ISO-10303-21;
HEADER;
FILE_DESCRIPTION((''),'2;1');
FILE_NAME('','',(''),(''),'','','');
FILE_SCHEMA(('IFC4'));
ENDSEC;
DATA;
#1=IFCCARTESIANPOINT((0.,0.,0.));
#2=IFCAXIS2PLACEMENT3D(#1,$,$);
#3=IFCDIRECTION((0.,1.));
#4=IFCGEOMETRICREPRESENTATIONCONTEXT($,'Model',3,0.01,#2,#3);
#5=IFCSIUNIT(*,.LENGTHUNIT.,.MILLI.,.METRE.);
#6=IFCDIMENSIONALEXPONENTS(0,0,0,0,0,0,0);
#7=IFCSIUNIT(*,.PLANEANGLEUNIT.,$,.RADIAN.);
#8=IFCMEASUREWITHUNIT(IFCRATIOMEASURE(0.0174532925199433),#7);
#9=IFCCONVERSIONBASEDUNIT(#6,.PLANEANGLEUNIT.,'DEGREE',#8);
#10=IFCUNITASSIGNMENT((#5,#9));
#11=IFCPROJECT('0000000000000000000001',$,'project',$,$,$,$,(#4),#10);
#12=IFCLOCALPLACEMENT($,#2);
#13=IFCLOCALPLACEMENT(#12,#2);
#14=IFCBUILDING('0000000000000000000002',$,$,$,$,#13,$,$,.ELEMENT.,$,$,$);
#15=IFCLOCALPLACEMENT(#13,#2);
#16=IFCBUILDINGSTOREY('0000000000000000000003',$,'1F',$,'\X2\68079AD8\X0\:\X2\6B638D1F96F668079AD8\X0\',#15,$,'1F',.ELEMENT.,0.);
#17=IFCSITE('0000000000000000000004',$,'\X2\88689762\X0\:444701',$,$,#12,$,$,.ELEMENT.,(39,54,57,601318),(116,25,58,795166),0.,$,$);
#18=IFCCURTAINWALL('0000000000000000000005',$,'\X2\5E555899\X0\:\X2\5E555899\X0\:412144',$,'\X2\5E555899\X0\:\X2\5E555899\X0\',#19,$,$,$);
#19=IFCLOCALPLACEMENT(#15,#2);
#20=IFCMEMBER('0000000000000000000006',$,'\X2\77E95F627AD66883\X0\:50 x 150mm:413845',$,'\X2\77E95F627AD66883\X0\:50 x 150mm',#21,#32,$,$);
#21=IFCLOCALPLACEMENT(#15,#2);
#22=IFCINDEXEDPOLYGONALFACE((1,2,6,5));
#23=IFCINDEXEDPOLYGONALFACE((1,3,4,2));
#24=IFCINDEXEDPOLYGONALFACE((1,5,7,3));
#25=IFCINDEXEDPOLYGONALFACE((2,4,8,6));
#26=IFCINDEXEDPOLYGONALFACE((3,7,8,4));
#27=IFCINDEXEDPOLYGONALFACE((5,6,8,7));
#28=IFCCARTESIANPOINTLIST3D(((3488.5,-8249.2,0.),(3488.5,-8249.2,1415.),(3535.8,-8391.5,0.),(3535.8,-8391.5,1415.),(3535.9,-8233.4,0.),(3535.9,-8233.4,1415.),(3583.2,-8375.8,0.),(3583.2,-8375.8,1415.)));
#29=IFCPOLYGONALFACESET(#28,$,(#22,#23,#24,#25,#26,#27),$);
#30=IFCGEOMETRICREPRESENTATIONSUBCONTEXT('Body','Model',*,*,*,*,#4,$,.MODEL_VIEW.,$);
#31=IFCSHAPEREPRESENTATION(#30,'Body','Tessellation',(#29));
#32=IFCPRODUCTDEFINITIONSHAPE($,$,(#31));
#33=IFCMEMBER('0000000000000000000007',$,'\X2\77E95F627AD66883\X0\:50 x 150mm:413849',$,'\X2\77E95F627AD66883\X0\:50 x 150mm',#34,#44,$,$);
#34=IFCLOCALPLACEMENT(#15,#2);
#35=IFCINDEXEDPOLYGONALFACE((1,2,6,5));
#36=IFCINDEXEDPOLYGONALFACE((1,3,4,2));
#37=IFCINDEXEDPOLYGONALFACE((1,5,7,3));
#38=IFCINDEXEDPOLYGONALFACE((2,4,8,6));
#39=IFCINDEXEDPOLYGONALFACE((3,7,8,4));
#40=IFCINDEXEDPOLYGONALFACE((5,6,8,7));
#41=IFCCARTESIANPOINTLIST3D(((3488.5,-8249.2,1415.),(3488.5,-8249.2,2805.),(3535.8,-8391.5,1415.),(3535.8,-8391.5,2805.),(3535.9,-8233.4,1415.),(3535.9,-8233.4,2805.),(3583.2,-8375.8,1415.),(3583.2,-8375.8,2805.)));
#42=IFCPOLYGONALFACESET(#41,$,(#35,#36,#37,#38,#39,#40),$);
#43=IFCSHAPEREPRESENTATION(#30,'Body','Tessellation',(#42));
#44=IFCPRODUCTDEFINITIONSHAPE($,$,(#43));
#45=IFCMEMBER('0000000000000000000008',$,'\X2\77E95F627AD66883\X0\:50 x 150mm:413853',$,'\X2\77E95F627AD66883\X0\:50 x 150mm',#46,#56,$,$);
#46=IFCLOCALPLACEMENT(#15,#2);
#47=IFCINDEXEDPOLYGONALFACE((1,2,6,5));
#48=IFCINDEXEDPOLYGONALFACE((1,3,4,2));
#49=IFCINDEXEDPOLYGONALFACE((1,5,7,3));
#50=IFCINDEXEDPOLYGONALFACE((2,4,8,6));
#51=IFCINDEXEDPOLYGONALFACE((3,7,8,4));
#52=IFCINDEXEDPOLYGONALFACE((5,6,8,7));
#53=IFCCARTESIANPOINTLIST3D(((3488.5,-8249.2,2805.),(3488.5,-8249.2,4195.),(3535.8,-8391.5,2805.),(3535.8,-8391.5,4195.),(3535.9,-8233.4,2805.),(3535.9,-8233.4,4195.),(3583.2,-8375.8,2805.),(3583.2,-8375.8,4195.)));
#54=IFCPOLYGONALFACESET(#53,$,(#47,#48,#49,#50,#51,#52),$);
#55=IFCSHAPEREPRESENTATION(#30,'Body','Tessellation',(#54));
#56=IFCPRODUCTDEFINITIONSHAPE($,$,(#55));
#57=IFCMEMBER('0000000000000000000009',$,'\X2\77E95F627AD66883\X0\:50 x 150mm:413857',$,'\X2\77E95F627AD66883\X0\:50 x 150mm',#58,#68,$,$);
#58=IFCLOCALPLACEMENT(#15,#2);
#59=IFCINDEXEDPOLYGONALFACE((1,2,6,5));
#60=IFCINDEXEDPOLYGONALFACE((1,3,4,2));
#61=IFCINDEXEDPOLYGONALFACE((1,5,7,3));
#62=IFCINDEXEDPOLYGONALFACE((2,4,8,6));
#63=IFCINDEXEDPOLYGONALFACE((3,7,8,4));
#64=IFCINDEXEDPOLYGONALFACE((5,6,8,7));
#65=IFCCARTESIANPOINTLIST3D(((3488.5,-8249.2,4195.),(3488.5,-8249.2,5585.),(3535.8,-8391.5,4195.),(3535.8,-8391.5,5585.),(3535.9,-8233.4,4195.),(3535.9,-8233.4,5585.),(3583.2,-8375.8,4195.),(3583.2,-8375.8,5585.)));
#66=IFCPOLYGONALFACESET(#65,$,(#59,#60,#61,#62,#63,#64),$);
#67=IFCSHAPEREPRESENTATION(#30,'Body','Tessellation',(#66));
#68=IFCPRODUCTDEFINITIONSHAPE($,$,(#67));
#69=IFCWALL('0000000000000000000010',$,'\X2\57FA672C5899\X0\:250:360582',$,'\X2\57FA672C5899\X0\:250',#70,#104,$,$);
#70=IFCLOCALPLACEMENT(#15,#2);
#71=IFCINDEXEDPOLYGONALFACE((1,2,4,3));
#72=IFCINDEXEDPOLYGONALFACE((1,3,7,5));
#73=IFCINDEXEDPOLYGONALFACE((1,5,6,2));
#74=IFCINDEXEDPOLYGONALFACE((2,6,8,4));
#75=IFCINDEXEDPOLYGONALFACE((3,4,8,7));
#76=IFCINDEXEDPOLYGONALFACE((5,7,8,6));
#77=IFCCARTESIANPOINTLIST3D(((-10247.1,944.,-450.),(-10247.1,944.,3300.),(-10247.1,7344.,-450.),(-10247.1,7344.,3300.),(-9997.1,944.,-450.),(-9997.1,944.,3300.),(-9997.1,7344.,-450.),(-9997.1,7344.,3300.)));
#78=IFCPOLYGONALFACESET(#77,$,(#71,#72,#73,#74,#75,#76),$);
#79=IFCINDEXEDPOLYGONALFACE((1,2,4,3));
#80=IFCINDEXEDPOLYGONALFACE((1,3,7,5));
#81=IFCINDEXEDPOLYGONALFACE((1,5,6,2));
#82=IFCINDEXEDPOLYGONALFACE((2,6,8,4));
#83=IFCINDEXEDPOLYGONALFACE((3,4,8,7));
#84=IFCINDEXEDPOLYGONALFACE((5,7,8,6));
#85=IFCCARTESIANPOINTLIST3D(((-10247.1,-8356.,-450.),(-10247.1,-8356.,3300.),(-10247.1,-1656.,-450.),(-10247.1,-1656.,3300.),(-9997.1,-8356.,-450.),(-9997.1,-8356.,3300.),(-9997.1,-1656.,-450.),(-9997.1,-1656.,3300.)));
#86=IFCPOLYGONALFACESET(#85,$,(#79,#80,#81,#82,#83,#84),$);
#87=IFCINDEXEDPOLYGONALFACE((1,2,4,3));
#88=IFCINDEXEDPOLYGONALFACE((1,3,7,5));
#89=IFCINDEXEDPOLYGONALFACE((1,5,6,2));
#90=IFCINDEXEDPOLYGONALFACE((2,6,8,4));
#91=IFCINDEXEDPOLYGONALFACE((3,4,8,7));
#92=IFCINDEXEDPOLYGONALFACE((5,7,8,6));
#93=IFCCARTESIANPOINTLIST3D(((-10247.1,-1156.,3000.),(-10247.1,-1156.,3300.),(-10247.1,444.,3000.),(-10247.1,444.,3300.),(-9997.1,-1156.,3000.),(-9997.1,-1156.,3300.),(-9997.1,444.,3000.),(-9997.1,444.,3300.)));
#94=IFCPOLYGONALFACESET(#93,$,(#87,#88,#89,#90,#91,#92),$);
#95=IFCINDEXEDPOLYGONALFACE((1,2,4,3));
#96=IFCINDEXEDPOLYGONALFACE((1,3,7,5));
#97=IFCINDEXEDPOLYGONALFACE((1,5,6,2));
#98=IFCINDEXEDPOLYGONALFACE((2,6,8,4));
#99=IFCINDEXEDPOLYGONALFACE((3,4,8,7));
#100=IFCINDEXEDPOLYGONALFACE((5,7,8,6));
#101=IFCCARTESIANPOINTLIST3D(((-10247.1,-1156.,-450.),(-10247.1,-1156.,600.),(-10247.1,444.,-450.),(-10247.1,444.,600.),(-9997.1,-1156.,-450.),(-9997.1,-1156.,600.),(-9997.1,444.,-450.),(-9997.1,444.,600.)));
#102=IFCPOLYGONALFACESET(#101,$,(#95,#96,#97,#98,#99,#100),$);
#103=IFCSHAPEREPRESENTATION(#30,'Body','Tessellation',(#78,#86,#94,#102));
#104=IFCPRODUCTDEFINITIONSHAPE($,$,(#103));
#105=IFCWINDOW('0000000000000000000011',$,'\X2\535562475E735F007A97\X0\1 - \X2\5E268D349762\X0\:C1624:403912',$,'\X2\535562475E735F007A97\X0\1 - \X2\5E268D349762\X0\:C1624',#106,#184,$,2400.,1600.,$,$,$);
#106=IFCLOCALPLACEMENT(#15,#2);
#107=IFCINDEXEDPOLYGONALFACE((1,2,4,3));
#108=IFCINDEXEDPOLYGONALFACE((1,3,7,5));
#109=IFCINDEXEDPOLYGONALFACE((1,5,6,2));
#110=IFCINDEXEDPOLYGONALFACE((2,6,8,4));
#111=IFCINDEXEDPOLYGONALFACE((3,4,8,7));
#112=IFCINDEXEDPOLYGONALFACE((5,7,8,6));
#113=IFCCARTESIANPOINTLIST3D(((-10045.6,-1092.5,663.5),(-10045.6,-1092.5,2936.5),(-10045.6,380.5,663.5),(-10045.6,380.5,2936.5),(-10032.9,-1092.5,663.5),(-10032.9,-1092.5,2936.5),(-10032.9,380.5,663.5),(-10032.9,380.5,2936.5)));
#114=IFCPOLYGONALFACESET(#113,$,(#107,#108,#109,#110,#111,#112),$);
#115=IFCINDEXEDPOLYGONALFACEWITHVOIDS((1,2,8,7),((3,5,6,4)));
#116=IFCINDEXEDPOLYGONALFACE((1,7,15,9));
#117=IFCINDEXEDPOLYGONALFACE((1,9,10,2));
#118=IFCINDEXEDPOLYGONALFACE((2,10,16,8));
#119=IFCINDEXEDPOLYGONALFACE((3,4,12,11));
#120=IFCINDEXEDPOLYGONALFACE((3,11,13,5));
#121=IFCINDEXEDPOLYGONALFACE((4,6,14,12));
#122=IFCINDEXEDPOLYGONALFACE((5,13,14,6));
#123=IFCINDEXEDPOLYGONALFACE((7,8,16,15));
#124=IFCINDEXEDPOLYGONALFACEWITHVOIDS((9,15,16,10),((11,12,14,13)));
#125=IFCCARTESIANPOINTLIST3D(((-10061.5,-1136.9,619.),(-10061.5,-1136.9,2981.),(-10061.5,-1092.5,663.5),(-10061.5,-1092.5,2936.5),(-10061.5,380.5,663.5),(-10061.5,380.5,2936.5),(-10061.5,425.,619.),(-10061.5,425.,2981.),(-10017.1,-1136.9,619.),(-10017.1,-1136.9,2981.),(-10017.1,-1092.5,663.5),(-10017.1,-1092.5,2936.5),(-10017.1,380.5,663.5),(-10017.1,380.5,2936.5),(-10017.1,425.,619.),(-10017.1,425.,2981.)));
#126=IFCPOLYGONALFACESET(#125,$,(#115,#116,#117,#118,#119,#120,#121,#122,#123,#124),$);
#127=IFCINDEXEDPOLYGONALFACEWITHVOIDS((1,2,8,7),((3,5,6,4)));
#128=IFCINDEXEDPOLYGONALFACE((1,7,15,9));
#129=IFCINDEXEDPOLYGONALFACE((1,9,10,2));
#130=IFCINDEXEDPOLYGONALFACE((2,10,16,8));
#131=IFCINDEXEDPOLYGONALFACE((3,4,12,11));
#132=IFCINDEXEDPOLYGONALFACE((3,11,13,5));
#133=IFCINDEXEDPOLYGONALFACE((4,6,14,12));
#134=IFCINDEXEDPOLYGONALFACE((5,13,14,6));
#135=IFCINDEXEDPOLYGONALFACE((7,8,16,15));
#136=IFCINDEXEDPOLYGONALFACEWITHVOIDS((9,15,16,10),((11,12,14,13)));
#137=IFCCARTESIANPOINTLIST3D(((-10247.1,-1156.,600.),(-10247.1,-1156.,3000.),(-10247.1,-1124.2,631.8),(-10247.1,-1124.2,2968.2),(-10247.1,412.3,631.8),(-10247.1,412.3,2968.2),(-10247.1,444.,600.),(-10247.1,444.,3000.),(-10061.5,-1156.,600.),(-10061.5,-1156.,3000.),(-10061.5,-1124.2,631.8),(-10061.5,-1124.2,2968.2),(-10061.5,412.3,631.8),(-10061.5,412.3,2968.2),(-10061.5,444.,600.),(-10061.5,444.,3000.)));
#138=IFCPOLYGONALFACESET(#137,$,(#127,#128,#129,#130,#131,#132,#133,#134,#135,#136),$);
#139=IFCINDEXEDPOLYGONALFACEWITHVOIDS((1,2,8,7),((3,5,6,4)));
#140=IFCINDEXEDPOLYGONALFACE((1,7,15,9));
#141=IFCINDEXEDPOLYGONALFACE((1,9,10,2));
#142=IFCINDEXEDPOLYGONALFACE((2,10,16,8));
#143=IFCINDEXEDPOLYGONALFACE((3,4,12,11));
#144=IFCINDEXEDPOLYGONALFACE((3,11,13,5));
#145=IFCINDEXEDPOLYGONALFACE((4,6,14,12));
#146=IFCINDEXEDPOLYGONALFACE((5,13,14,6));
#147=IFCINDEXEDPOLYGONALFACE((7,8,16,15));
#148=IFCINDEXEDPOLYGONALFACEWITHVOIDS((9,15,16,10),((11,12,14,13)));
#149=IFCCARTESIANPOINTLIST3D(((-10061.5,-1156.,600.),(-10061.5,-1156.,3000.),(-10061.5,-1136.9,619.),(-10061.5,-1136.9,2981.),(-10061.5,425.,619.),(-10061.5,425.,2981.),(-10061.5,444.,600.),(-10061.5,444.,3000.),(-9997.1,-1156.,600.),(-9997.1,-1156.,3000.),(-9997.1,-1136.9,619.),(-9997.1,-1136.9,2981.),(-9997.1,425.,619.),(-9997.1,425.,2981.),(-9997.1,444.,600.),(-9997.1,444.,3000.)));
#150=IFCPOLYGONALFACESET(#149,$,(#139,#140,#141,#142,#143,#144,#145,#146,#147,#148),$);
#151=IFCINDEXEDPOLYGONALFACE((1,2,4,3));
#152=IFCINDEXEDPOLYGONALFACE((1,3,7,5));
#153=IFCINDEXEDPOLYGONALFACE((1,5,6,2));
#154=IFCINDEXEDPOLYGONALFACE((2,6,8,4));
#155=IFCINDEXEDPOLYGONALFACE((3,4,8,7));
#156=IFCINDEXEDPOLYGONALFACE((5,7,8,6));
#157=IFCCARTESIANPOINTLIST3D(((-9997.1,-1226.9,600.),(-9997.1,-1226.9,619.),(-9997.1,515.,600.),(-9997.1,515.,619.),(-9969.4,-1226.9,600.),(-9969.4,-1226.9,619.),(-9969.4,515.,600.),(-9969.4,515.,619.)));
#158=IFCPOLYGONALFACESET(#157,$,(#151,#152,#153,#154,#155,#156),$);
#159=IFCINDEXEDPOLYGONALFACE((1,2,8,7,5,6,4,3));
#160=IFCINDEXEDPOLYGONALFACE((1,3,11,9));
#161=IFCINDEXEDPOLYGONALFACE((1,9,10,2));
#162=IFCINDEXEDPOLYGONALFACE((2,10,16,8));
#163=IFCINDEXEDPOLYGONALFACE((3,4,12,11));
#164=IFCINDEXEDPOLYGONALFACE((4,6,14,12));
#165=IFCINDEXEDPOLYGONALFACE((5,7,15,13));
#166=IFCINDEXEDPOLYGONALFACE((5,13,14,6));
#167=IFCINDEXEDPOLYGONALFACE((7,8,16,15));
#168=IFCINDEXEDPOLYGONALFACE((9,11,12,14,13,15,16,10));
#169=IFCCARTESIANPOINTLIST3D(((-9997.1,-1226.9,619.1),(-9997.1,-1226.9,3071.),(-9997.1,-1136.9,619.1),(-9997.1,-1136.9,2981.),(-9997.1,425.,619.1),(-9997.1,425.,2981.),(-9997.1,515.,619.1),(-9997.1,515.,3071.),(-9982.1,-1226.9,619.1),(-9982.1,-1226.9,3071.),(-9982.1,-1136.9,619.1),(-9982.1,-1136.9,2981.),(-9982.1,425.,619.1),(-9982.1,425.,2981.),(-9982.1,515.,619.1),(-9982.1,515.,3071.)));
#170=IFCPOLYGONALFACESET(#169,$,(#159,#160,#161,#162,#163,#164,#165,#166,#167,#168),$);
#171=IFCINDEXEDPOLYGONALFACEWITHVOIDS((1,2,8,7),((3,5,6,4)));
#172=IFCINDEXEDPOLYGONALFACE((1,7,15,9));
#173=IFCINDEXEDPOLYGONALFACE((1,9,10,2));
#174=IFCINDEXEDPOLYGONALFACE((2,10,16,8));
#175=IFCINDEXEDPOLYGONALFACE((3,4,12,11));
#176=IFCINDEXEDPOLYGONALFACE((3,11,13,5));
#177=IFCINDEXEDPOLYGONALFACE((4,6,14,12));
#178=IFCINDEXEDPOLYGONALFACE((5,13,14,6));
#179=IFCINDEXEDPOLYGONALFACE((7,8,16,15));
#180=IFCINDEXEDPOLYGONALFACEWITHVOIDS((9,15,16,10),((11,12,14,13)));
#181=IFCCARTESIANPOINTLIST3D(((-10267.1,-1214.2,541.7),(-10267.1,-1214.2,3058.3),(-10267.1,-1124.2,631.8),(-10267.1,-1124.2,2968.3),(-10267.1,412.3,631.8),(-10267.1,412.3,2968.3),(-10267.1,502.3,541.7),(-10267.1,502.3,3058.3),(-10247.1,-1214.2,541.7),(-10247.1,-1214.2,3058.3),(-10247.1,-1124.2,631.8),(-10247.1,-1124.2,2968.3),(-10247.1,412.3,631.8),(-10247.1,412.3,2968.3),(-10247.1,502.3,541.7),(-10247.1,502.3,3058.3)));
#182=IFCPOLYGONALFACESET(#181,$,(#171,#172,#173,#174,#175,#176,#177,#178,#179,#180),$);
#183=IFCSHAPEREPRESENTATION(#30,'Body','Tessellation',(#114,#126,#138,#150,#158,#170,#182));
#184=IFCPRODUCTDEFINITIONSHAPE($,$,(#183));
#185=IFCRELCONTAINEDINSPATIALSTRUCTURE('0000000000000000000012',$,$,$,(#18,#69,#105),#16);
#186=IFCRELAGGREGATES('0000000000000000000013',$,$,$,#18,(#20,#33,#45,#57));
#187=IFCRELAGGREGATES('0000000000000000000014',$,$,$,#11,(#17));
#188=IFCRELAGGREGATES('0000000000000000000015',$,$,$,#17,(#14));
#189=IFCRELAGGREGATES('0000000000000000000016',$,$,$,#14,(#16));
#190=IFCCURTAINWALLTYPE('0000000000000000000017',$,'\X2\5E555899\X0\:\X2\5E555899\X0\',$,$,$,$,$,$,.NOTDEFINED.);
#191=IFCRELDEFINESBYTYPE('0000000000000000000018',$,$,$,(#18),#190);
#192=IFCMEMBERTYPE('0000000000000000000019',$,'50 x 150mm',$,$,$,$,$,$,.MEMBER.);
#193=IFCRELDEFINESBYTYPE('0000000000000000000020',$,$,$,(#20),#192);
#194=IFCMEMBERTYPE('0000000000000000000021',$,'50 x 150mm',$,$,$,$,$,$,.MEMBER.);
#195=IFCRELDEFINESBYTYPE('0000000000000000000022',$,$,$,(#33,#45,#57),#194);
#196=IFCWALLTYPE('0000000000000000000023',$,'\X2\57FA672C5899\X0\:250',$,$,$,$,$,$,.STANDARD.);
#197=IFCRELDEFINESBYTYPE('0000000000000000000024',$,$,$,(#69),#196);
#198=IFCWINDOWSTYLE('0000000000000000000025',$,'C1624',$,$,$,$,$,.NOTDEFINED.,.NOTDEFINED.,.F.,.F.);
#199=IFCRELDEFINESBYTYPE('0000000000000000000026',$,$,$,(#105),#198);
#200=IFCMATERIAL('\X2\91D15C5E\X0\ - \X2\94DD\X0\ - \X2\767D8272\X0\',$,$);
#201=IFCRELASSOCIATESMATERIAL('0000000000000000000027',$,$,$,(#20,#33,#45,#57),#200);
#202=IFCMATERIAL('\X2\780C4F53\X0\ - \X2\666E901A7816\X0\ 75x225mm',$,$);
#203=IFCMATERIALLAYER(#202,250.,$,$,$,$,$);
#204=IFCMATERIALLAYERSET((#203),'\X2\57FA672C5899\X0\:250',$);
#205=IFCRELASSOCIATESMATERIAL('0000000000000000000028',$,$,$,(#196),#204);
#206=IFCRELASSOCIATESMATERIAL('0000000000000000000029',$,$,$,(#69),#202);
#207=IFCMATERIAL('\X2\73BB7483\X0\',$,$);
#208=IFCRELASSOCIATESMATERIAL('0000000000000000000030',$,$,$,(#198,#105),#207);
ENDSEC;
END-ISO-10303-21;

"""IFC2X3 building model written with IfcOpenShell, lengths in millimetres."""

from ifc_helpers import new_model, entity, si_unit, converted_unit, direction, frame, frame_2d, origin, origin_2d_with_axis, place, context, subcontext, project, spatial, polyline, rectangle, outline, extrude, source, transform, mapped, material, layer, layer_set, type_object, type_shapes, element, fill, aggregate, save


model = new_model("IFC2X3")

# Units and contexts
model_context = context("Model", 3, precision=0.01, world=origin(), true_north=direction((0.0, 1.0)))
body_context = subcontext(model_context, "Body", "Model", "MODEL_VIEW")
ifc_project = project(units=[si_unit("LENGTHUNIT", "METRE", prefix="MILLI"), converted_unit("PLANEANGLEUNIT", "DEGREE", entity("IfcRatioMeasure", 0.0174532925199433), si_unit("PLANEANGLEUNIT", "RADIAN"), dimensions=[0, 0, 0, 0, 0, 0, 0])], contexts=[model_context])

# Site, building, storey
site_placement = place(None, origin())
site = spatial("IfcSite", under=ifc_project, at=site_placement, Name="表面:444701", CompositionType="ELEMENT", RefLatitude=(39, 54, 57, 601318), RefLongitude=(116, 25, 58, 795166), RefElevation=0.0)
building_placement = place(site_placement, origin())
building = spatial("IfcBuilding", under=site, at=building_placement, CompositionType="ELEMENT")
storey_placement = place(building_placement, origin())
storey = spatial("IfcBuildingStorey", under=building, at=storey_placement, Name="1F", ObjectType="标高:正负零标高", LongName="1F", CompositionType="ELEMENT", Elevation=0.0)

# Curtain wall, members
curtain_wall_type = type_object("IfcCurtainWallType", Name="幕墙:幕墙", PredefinedType="NOTDEFINED")
curtain_wall_placement = place(storey_placement, origin())
curtain_wall = element("IfcCurtainWall", 1, at=curtain_wall_placement, inside=storey, type_object=curtain_wall_type, Name="幕墙:幕墙:412144", ObjectType="幕墙:幕墙")
ifc_material_1 = material(Name="金属 - 铝 - 白色")
member_type_1 = type_object("IfcMemberType", Name="50 x 150mm", PredefinedType="MEMBER")
shared_shape_1 = source(origin(), body_context, "Body", "SweptSolid", [
    extrude(rectangle(XDim=150.0, YDim=50.0, at=origin_2d_with_axis()), frame((0.0, 0.0, -1415.0), z_axis=(0.0, 0.0, 1.0), x_axis=(0.0, -1.0, 0.0)), (0.0, 0.0, 1.0), 1415.0),
])
type_shapes(member_type_1, [shared_shape_1])
member_1_placement = place(storey_placement, frame((3535.8, -8312.5, 0.0), z_axis=(0.0, 0.0, -1.0), x_axis=(0.949018, 0.315223, 0.0)))
member_1 = element("IfcMember", 2, at=member_1_placement, type_object=member_type_1, material=ifc_material_1, Name="矩形竖梃:50 x 150mm:413845", ObjectType="矩形竖梃:50 x 150mm", context=body_context, shape_type="MappedRepresentation", body=[
    mapped(shared_shape_1, transform((0.0, 0.0, 0.0), scale=1.0)),
])
member_type_2 = type_object("IfcMemberType", Name="50 x 150mm", PredefinedType="MEMBER")
shared_shape_2 = source(origin(), body_context, "Body", "SweptSolid", [
    extrude(rectangle(XDim=150.0, YDim=50.0, at=origin_2d_with_axis()), frame((0.0, 0.0, -1390.0), z_axis=(0.0, 0.0, 1.0), x_axis=(0.0, -1.0, 0.0)), (0.0, 0.0, 1.0), 1390.0),
])
type_shapes(member_type_2, [shared_shape_2])
member_2_placement = place(storey_placement, frame((3535.8, -8312.5, 1415.0), z_axis=(0.0, 0.0, -1.0), x_axis=(0.949018, 0.315223, 0.0)))
member_2 = element("IfcMember", 3, at=member_2_placement, type_object=member_type_2, material=ifc_material_1, Name="矩形竖梃:50 x 150mm:413849", ObjectType="矩形竖梃:50 x 150mm", context=body_context, shape_type="MappedRepresentation", body=[
    mapped(shared_shape_2, transform((0.0, 0.0, 0.0), scale=1.0)),
])
member_3_placement = place(storey_placement, frame((3535.8, -8312.5, 2805.0), z_axis=(0.0, 0.0, -1.0), x_axis=(0.949018, 0.315223, 0.0)))
member_3 = element("IfcMember", 4, at=member_3_placement, type_object=member_type_2, material=ifc_material_1, Name="矩形竖梃:50 x 150mm:413853", ObjectType="矩形竖梃:50 x 150mm", context=body_context, shape_type="MappedRepresentation", body=[
    mapped(shared_shape_2, transform((0.0, 0.0, 0.0), scale=1.0)),
])
member_4_placement = place(storey_placement, frame((3535.8, -8312.5, 4195.0), z_axis=(0.0, 0.0, -1.0), x_axis=(0.949018, 0.315223, 0.0)))
member_4 = element("IfcMember", 5, at=member_4_placement, type_object=member_type_2, material=ifc_material_1, Name="矩形竖梃:50 x 150mm:413857", ObjectType="矩形竖梃:50 x 150mm", context=body_context, shape_type="MappedRepresentation", body=[
    mapped(shared_shape_2, transform((0.0, 0.0, 0.0), scale=1.0)),
])
aggregate(curtain_wall, [member_1, member_2, member_3, member_4])

# Wall, opening, window
ifc_material_2 = material(Name="砌体 - 普通砖 75x225mm")
ifc_layer_1 = layer(ifc_material_2, 250.0)
ifc_layer_set_1 = layer_set([ifc_layer_1], Name="基本墙:250")
wall_type_1 = type_object("IfcWallType", Name="基本墙:250", PredefinedType="STANDARD", material=ifc_layer_set_1)
wall_1_placement = place(storey_placement, frame((-10122.1, 7344.0, -450.0), z_axis=(0.0, 0.0, 1.0), x_axis=(0.0, -1.0, 0.0)))
wall_1 = element("IfcWall", 6, at=wall_1_placement, inside=storey, type_object=wall_type_1, material=ifc_material_2, Name="基本墙:250:360582", ObjectType="基本墙:250", context=body_context, shape_type="SweptSolid", body=[
    extrude(rectangle(XDim=6400.0, YDim=250.0, at=frame_2d((0.0, 0.0), x_axis=(1.0, 0.0))), frame((3200.0, 0.0, 0.0), z_axis=(0.0, 0.0, 1.0), x_axis=(-1.0, 0.0, 0.0)), (0.0, 0.0, 1.0), 3750.0),
    extrude(rectangle(XDim=6700.0, YDim=250.0, at=frame_2d((0.0, 0.0), x_axis=(1.0, 0.0))), frame((12350.0, 0.0, 0.0), z_axis=(0.0, 0.0, 1.0), x_axis=(-1.0, 0.0, 0.0)), (0.0, 0.0, 1.0), 3750.0),
    extrude(rectangle(XDim=250.0, YDim=1600.0, at=frame_2d((0.0, 0.0), x_axis=(1.0, 0.0))), frame((7700.0, 0.0, 3450.0), z_axis=(0.0, 0.0, 1.0), x_axis=(0.0, 1.0, 0.0)), (0.0, 0.0, 1.0), 300.0),
    extrude(rectangle(XDim=1600.0, YDim=250.0, at=origin_2d_with_axis()), frame((7700.0, 0.0, 0.0), z_axis=(0.0, 0.0, 1.0), x_axis=(-1.0, 0.0, 0.0)), (0.0, 0.0, 1.0), 1050.0),
])
opening_1_placement = place(wall_1_placement, frame((6900.0, -125.0, 1050.0)))
opening_1 = element("IfcOpeningElement", 7, at=opening_1_placement, cuts=wall_1, ObjectType="Opening", context=body_context, shape_type="SweptSolid", body=[
    extrude(rectangle(XDim=2400.0, YDim=1600.0, at=frame_2d((1200.0, 800.0), x_axis=(-1.0, 0.0))), frame((0.0, 0.0, 0.0), z_axis=(0.0, 1.0, 0.0), x_axis=(0.0, 0.0, 1.0)), (0.0, 0.0, 1.0), 250.0),
])
ifc_material_3 = material(Name="玻璃")
window_style_1 = type_object("IfcWindowStyle", Name="C1624", ConstructionType="NOTDEFINED", OperationType="NOTDEFINED", ParameterTakesPrecedence=False, Sizeable=False, material=ifc_material_3)
shared_shape_3 = source(origin(), body_context, "Body", "SweptSolid", [
    extrude(rectangle(XDim=12.7, YDim=1473.0, at=origin_2d_with_axis()), frame((800.0, 207.8, 63.5), z_axis=(0.0, 0.0, 1.0), x_axis=(0.0, 1.0, 0.0)), (0.0, 0.0, 1.0), 2273.0),
    extrude(outline(polyline([(-780.9, -1181.0), (780.9, -1181.0), (780.9, 1181.0), (-780.9, 1181.0), (-780.9, -1181.0)]), holes=[polyline([(-736.5, -1136.5), (-736.5, 1136.5), (736.5, 1136.5), (736.5, -1136.5), (-736.5, -1136.5)])]), frame((800.0, 185.6, 1200.0), z_axis=(0.0, 1.0, 0.0), x_axis=(1.0, 0.0, 0.0)), (0.0, 0.0, 1.0), 44.5),
    extrude(outline(polyline([(-800.0, -1200.0), (800.0, -1200.0), (800.0, 1200.0), (-800.0, 1200.0), (-800.0, -1200.0)]), holes=[polyline([(-768.2, -1168.2), (-768.2, 1168.2), (768.2, 1168.2), (768.2, -1168.2), (-768.2, -1168.2)])]), frame((800.0, 0.0, 1200.0), z_axis=(0.0, 1.0, 0.0), x_axis=(1.0, 0.0, 0.0)), (0.0, 0.0, 1.0), 185.6),
    extrude(outline(polyline([(-1200.0, -800.0), (1200.0, -800.0), (1200.0, 800.0), (-1200.0, 800.0), (-1200.0, -800.0)]), holes=[polyline([(-1181.0, -780.9), (-1181.0, 781.0), (1181.0, 781.0), (1181.0, -780.9), (-1181.0, -780.9)])]), frame((800.0, 185.6, 1200.0), z_axis=(0.0, 1.0, 0.0), x_axis=(0.0, 0.0, -1.0)), (0.0, 0.0, 1.0), 64.5),
    extrude(rectangle(XDim=27.7, YDim=1741.9, at=frame_2d((0.0, 0.0), x_axis=(1.0, 0.0))), frame((800.0, 263.9, 0.0), z_axis=(0.0, 0.0, 1.0), x_axis=(0.0, -1.0, 0.0)), (0.0, 0.0, 1.0), 19.0),
    extrude(outline(polyline([(-1158.5, 780.9), (1203.5, 780.9), (1203.5, 870.9), (-1248.5, 870.9), (-1248.5, -870.9), (1203.5, -870.9), (1203.5, -780.9), (-1158.5, -780.9), (-1158.5, 780.9)])), frame((800.0, 250.0, 1222.5), z_axis=(0.0, 1.0, 0.0), x_axis=(0.0, 0.0, -1.0)), (0.0, 0.0, 1.0), 15.0),
    extrude(outline(polyline([(-1258.3, -858.2), (1258.3, -858.2), (1258.3, 858.2), (-1258.3, 858.2), (-1258.3, -858.2)]), holes=[polyline([(-1168.3, -768.2), (-1168.3, 768.3), (1168.2, 768.3), (1168.2, -768.2), (-1168.3, -768.2)])]), frame((800.0, -20.0, 1200.0), z_axis=(0.0, 1.0, 0.0), x_axis=(0.0, 0.0, -1.0)), (0.0, 0.0, 1.0), 20.0),
])
type_shapes(window_style_1, [shared_shape_3])
window_1_placement = place(opening_1_placement, origin())
window_1 = element("IfcWindow", 8, at=window_1_placement, inside=storey, type_object=window_style_1, material=ifc_material_3, Name="单扇平开窗1 - 带贴面:C1624:403912", ObjectType="单扇平开窗1 - 带贴面:C1624", OverallHeight=2400.0, OverallWidth=1600.0, context=body_context, shape_type="MappedRepresentation", body=[
    mapped(shared_shape_3, transform((0.0, 0.0, 0.0), scale=1.0)),
])
fill(opening_1, window_1)

save(model, "model.ifc")
